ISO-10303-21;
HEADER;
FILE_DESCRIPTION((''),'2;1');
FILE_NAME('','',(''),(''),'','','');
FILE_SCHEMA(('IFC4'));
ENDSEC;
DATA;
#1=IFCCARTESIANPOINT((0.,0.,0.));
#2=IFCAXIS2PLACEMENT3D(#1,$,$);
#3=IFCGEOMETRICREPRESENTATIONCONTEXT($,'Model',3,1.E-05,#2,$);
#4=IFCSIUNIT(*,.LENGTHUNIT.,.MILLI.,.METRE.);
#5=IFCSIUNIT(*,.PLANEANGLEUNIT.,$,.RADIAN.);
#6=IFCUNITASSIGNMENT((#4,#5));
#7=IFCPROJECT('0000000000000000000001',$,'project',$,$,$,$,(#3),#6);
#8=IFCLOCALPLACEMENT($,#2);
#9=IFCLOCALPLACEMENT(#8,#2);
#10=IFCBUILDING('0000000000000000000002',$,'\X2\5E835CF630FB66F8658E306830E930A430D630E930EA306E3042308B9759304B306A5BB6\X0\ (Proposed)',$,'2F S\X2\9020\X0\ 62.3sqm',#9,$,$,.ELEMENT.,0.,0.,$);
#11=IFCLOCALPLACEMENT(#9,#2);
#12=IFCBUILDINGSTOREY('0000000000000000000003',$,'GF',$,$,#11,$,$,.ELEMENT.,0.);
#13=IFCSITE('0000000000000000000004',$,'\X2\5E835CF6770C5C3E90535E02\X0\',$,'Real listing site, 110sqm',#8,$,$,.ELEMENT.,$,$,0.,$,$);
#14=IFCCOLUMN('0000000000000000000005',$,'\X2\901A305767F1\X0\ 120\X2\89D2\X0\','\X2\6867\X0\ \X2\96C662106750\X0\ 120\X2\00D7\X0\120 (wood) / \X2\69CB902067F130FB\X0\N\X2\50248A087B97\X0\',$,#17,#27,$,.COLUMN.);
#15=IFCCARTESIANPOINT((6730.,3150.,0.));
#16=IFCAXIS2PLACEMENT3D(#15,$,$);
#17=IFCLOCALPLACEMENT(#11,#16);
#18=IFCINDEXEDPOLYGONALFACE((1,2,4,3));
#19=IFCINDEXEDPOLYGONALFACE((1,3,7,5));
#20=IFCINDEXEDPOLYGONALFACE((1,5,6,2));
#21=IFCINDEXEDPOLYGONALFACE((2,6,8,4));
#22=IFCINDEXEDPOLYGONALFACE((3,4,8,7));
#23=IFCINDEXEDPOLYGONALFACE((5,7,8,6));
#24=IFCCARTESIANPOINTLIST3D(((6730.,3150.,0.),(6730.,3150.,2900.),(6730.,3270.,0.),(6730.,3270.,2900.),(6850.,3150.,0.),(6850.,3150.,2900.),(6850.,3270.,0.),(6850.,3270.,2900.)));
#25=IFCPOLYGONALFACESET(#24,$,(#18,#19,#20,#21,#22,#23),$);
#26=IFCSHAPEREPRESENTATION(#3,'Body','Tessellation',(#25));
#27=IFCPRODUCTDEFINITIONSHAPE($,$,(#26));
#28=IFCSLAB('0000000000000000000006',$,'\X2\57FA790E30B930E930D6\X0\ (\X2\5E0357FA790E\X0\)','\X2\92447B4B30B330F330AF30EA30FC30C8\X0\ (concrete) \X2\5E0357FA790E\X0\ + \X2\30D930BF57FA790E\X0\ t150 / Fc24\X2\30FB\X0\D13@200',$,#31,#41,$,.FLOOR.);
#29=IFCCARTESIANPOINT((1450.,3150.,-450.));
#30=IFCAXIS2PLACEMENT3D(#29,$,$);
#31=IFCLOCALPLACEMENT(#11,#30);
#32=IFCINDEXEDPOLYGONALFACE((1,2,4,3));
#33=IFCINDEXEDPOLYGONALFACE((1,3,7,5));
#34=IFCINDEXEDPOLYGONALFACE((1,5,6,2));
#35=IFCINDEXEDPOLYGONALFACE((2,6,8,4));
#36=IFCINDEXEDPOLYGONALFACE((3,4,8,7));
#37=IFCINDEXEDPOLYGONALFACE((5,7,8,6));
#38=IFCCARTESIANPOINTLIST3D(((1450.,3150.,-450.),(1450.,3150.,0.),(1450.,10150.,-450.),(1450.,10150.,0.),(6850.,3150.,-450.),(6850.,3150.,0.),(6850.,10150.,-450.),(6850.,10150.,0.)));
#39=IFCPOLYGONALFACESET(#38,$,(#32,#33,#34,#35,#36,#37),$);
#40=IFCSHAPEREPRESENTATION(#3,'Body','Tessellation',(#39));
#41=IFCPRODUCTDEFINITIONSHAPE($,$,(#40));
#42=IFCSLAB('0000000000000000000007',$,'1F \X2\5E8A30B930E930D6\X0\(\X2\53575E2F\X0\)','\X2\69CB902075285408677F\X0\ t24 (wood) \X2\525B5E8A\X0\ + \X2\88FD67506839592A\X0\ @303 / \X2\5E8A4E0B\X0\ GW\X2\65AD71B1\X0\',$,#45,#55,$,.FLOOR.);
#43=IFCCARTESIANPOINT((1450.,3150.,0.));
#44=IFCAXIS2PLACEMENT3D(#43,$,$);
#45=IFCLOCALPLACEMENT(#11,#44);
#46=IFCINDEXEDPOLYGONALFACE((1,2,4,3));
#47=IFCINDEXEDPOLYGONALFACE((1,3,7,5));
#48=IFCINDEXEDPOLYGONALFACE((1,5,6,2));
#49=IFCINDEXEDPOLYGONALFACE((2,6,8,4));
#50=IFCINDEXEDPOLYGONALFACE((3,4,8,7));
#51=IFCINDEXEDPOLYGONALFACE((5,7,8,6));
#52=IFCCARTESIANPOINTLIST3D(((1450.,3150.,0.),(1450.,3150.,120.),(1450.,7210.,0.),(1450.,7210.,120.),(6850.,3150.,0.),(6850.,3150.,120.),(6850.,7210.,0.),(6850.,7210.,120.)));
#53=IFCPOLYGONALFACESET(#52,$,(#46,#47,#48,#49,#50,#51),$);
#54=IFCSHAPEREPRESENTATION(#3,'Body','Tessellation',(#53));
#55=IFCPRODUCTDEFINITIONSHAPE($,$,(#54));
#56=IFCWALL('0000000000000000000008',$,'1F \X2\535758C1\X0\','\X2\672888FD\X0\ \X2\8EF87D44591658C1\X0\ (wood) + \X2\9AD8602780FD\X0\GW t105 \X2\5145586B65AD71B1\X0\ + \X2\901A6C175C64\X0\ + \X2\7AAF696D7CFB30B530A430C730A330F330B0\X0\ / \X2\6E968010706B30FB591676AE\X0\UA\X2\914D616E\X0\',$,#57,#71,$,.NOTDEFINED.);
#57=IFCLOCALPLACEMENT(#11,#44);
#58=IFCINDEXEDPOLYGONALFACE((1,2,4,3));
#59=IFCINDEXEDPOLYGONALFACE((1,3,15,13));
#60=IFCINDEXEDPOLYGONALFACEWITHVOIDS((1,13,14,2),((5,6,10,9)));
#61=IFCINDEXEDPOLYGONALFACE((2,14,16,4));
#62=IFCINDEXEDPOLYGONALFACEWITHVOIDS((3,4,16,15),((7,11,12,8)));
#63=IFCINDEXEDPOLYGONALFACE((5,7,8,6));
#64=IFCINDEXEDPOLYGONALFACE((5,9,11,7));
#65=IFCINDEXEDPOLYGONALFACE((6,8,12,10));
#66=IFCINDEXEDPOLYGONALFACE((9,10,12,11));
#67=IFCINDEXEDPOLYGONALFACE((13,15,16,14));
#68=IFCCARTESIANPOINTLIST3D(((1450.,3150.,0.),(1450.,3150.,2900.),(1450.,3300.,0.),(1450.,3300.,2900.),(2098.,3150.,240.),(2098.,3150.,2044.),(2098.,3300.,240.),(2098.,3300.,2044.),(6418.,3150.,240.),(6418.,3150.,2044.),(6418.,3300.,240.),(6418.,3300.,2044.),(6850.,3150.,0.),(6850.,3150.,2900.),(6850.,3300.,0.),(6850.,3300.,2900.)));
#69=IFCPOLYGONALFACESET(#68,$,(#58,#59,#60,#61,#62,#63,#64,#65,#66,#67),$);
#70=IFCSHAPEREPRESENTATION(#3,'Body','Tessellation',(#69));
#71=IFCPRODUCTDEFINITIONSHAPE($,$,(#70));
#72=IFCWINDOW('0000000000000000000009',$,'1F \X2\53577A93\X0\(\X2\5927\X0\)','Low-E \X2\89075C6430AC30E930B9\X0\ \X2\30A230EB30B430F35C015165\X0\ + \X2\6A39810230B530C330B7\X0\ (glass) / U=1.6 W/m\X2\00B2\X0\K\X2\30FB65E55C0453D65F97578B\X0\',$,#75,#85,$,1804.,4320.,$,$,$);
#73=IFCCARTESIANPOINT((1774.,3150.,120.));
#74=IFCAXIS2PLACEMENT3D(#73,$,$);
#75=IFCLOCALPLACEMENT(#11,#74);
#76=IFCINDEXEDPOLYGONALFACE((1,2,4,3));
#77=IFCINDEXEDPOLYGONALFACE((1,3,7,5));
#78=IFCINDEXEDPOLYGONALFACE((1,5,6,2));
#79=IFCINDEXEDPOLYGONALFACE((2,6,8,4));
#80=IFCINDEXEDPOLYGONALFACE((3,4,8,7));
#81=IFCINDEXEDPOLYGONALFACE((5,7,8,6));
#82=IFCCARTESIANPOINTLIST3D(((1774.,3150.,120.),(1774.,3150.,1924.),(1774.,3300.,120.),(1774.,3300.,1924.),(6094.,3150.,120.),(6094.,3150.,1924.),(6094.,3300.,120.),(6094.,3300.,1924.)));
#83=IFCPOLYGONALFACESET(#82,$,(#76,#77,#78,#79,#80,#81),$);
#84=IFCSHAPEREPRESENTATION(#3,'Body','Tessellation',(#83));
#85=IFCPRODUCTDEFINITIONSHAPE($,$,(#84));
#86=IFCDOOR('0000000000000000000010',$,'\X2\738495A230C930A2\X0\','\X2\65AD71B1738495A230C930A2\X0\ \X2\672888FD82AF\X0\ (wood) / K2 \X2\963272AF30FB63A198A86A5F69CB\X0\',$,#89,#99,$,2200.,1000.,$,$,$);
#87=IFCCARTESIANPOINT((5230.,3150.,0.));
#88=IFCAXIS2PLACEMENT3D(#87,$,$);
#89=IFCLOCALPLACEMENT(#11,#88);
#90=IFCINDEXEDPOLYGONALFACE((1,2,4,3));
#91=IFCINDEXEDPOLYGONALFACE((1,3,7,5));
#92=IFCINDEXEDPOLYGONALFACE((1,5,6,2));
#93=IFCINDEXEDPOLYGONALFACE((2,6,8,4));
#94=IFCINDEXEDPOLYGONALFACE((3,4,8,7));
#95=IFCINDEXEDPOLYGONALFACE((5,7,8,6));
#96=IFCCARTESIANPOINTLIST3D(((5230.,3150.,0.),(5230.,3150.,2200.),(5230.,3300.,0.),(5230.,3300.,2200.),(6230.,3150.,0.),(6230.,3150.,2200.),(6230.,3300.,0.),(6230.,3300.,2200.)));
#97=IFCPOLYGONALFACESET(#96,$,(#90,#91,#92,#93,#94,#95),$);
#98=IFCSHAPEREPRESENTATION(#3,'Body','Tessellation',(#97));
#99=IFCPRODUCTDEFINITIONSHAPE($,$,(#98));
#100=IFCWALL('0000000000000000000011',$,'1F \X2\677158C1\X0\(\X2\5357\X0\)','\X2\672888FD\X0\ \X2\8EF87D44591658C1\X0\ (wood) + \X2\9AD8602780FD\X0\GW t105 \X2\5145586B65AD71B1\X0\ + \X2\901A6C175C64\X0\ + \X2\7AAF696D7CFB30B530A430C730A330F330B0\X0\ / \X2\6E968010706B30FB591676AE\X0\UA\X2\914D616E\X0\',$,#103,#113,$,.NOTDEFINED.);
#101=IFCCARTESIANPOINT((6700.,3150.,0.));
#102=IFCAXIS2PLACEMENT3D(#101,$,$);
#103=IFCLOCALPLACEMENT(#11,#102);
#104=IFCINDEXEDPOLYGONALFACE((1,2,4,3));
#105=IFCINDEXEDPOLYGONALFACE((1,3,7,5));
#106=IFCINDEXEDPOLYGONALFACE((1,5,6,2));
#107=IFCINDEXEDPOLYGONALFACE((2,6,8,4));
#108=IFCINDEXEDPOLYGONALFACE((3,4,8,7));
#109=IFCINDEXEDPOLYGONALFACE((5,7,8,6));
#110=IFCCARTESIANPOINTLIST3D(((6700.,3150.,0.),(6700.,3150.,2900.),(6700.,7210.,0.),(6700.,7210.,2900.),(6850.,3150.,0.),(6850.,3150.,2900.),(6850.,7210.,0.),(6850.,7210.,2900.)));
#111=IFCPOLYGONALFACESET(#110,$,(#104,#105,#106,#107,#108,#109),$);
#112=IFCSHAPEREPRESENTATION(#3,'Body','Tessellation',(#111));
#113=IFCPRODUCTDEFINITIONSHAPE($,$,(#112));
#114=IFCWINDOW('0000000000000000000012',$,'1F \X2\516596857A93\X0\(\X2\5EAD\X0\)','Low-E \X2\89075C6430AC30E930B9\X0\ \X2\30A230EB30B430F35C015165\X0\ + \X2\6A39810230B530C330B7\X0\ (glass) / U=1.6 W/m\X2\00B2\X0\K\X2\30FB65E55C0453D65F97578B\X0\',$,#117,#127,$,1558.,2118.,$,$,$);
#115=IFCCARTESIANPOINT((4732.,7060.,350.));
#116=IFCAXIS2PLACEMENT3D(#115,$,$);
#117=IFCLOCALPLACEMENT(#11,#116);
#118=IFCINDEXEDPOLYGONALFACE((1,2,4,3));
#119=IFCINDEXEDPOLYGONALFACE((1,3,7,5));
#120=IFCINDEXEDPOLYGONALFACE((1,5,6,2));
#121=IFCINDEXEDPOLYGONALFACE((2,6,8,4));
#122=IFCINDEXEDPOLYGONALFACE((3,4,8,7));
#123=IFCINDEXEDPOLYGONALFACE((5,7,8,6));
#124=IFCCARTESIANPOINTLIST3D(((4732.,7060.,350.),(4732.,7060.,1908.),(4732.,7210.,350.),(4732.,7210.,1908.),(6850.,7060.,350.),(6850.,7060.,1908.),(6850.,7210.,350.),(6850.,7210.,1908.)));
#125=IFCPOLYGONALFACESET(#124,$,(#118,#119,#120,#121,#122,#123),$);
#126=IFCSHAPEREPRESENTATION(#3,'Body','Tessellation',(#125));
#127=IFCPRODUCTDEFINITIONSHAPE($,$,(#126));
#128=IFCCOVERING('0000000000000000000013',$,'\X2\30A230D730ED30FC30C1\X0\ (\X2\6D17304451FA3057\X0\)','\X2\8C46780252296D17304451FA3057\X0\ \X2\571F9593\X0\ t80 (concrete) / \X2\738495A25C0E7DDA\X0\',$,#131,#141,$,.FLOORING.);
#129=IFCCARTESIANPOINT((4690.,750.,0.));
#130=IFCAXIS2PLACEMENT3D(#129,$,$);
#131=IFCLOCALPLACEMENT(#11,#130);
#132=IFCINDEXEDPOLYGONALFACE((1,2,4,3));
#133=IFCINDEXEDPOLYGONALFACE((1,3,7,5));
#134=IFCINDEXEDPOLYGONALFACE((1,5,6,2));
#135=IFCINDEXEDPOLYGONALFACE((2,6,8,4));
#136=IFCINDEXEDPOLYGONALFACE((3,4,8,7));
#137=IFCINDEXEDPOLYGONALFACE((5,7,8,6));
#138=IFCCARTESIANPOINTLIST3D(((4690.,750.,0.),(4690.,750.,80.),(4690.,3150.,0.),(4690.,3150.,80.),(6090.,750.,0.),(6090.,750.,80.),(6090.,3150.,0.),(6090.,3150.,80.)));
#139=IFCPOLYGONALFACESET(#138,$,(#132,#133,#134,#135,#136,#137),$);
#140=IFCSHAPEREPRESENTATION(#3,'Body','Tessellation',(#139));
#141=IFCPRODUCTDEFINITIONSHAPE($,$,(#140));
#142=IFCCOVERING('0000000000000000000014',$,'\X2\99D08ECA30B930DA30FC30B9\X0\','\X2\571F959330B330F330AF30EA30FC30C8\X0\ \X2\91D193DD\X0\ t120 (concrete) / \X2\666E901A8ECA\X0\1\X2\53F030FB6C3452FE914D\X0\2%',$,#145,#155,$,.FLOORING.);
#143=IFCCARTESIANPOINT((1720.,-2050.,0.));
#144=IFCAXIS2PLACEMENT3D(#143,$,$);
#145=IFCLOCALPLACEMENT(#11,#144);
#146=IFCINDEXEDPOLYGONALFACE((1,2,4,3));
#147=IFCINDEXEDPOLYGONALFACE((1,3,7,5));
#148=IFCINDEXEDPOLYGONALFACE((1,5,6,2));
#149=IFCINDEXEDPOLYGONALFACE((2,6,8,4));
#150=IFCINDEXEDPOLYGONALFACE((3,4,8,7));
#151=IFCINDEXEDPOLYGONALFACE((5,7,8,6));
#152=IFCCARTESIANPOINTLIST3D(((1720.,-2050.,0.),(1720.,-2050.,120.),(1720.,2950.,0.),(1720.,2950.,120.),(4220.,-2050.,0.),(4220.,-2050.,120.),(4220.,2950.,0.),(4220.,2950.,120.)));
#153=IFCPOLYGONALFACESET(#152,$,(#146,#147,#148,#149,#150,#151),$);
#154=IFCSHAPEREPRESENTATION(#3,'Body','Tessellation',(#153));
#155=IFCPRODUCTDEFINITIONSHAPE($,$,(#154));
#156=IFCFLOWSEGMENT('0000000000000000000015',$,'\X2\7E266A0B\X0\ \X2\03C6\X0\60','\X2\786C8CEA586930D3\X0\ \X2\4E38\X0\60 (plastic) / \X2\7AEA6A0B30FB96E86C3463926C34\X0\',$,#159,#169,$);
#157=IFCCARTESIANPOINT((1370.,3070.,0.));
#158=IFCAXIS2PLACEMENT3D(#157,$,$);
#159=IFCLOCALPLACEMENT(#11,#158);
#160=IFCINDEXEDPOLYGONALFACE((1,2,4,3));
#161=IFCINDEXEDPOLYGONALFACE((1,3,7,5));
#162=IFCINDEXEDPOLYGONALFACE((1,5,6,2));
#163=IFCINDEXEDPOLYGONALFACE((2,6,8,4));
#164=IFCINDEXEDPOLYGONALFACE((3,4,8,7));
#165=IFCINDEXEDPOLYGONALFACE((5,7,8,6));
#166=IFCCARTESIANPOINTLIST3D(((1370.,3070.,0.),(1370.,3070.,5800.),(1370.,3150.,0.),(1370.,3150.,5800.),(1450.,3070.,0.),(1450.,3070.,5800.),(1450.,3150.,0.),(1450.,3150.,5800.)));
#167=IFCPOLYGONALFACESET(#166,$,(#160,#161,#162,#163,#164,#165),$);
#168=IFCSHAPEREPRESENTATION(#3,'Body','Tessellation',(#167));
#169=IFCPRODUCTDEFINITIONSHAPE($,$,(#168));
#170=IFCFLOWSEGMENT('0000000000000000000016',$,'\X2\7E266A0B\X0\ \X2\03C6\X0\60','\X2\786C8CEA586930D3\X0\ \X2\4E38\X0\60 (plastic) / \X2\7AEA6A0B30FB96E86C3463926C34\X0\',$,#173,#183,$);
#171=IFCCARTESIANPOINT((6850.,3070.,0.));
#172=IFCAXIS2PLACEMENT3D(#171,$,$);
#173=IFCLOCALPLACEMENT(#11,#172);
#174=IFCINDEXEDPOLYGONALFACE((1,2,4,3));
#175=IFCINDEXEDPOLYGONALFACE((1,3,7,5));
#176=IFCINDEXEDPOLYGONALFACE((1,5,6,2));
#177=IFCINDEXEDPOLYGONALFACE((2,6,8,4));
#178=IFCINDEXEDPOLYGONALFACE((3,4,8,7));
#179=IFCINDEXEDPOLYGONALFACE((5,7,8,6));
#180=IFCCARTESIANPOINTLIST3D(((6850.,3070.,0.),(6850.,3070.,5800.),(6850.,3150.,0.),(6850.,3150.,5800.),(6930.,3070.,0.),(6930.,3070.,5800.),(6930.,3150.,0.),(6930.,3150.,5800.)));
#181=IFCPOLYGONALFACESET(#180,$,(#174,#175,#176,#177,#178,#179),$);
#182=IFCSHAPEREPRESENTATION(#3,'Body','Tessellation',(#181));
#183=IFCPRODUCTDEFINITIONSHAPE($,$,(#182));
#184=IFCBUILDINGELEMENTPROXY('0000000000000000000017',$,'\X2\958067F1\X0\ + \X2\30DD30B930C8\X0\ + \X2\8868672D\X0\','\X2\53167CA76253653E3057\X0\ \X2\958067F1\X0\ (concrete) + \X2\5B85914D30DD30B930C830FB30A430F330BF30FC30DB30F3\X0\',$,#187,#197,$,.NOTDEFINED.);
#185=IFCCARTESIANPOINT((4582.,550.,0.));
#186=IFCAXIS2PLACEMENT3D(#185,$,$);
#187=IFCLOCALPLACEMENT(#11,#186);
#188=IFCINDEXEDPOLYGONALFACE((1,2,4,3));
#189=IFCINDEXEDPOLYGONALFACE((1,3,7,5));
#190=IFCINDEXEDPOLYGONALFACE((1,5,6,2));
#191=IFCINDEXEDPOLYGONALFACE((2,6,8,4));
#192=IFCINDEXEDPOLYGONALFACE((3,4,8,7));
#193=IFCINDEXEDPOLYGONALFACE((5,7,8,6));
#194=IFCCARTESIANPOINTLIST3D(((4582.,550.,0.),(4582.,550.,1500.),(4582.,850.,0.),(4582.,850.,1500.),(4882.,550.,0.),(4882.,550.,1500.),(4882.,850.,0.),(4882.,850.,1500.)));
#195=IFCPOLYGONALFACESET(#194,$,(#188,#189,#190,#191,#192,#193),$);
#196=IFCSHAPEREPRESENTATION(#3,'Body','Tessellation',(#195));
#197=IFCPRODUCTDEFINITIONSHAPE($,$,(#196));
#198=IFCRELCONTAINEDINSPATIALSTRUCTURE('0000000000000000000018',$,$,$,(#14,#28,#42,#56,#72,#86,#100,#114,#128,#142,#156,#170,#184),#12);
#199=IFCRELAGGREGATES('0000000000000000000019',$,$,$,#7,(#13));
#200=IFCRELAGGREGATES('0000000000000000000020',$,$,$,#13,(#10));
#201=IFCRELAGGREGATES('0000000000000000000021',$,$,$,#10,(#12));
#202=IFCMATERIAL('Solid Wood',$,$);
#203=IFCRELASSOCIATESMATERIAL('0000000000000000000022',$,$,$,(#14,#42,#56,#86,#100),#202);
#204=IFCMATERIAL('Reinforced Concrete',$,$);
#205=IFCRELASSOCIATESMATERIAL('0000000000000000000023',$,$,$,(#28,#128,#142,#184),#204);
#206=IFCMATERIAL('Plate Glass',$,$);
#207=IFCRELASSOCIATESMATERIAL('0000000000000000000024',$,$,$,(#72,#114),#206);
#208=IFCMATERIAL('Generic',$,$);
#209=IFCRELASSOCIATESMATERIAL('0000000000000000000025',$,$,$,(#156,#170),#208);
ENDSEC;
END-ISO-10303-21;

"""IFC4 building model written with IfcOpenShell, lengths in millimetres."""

from ifc_helpers import new_model, si_unit, frame, frame_2d, origin, place, context, project, spatial, rectangle, extrude, material, element, fill, save


model = new_model("IFC4")

# Units and contexts
model_context = context("Model", 3, precision=1e-05, world=origin())
ifc_project = project(units=[si_unit("LENGTHUNIT", "METRE", prefix="MILLI"), si_unit("PLANEANGLEUNIT", "RADIAN")], contexts=[model_context])

# Site, building, storey
site_placement = place(None, origin())
site = spatial("IfcSite", under=ifc_project, at=site_placement, Name="広島県尾道市", ObjectType="Real listing site, 110sqm", CompositionType="ELEMENT", RefElevation=0.0)
building_placement = place(site_placement, origin())
building = spatial("IfcBuilding", under=site, at=building_placement, Name="広島・書斎とライブラリのある静かな家 (Proposed)", ObjectType="2F S造 62.3sqm", CompositionType="ELEMENT", ElevationOfRefHeight=0.0, ElevationOfTerrain=0.0)
storey_placement = place(building_placement, origin())
storey = spatial("IfcBuildingStorey", under=building, at=storey_placement, Name="GF", CompositionType="ELEMENT", Elevation=0.0)

# Column
ifc_material_1 = material(Name="Solid Wood")
column_1_placement = place(storey_placement, frame((6730.0, 3150.0, 0.0)))
element("IfcColumn", 1, at=column_1_placement, inside=storey, material=ifc_material_1, Name="通し柱 120角", Description="桧 集成材 120×120 (wood) / 構造柱・N値計算", PredefinedType="COLUMN", context=model_context, shape_type="SweptSolid", body=[
    extrude(rectangle(XDim=120.0, YDim=120.0, at=frame_2d((60.0, 60.0))), frame((6730.0, 3150.0, 0.0)), (0.0, 0.0, 1.0), 2900.0),
])

# Slabs
ifc_material_2 = material(Name="Reinforced Concrete")
slab_1_placement = place(storey_placement, frame((1450.0, 3150.0, -450.0)))
element("IfcSlab", 2, at=slab_1_placement, inside=storey, material=ifc_material_2, Name="基礎スラブ (布基礎)", Description="鉄筋コンクリート (concrete) 布基礎 + ベタ基礎 t150 / Fc24・D13@200", PredefinedType="FLOOR", context=model_context, shape_type="SweptSolid", body=[
    extrude(rectangle(XDim=5400.0, YDim=7000.0, at=frame_2d((2700.0, 3500.0))), frame((1450.0, 3150.0, -450.0)), (0.0, 0.0, 1.0), 450.0),
])
slab_2_placement = place(storey_placement, frame((1450.0, 3150.0, 0.0)))
element("IfcSlab", 3, at=slab_2_placement, inside=storey, material=ifc_material_1, Name="1F 床スラブ(南帯)", Description="構造用合板 t24 (wood) 剛床 + 製材根太 @303 / 床下 GW断熱", PredefinedType="FLOOR", context=model_context, shape_type="SweptSolid", body=[
    extrude(rectangle(XDim=5400.0, YDim=4060.0, at=frame_2d((2700.0, 2030.0))), frame((1450.0, 3150.0, 0.0)), (0.0, 0.0, 1.0), 120.0),
])

# Wall, openings, window, door
wall_1_placement = place(storey_placement, frame((1450.0, 3150.0, 0.0)))
wall_1 = element("IfcWall", 4, at=wall_1_placement, inside=storey, material=ifc_material_1, Name="1F 南壁", Description="木製 軸組外壁 (wood) + 高性能GW t105 充填断熱 + 通気層 + 窯業系サイディング / 準耐火・外皮UA配慮", PredefinedType="NOTDEFINED", context=model_context, shape_type="SweptSolid", body=[
    extrude(rectangle(XDim=5400.0, YDim=150.0, at=frame_2d((2700.0, 75.0))), frame((1450.0, 3150.0, 0.0)), (0.0, 0.0, 1.0), 2900.0),
])
opening_1_placement = place(storey_placement, frame((1774.0, 3150.0, 120.0)))
opening_1 = element("IfcOpeningElement", 5, at=opening_1_placement, cuts=wall_1, PredefinedType="NOTDEFINED", context=model_context, shape_type="SweptSolid", body=[
    extrude(rectangle(XDim=4320.0, YDim=150.0, at=frame_2d((2160.0, 75.0))), frame((1774.0, 3150.0, 120.0)), (0.0, 0.0, 1.0), 1804.0),
])
opening_2_placement = place(storey_placement, frame((5230.0, 3150.0, 0.0)))
opening_2 = element("IfcOpeningElement", 6, at=opening_2_placement, cuts=wall_1, PredefinedType="NOTDEFINED", context=model_context, shape_type="SweptSolid", body=[
    extrude(rectangle(XDim=1000.0, YDim=150.0, at=frame_2d((500.0, 75.0))), frame((5230.0, 3150.0, 0.0)), (0.0, 0.0, 1.0), 2200.0),
])
ifc_material_3 = material(Name="Plate Glass")
window_1_placement = place(storey_placement, frame((1774.0, 3150.0, 120.0)))
window_1 = element("IfcWindow", 7, at=window_1_placement, inside=storey, material=ifc_material_3, Name="1F 南窓(大)", Description="Low-E 複層ガラス アルゴン封入 + 樹脂サッシ (glass) / U=1.6 W/m²K・日射取得型", OverallHeight=1804.0, OverallWidth=4320.0, context=model_context, shape_type="SweptSolid", body=[
    extrude(rectangle(XDim=4320.0, YDim=150.0, at=frame_2d((2160.0, 75.0))), frame((1774.0, 3150.0, 120.0)), (0.0, 0.0, 1.0), 1804.0),
])
fill(opening_1, window_1)
door_1_placement = place(storey_placement, frame((5230.0, 3150.0, 0.0)))
door_1 = element("IfcDoor", 8, at=door_1_placement, inside=storey, material=ifc_material_1, Name="玄関ドア", Description="断熱玄関ドア 木製芯 (wood) / K2 防犯・採風機構", OverallHeight=2200.0, OverallWidth=1000.0, context=model_context, shape_type="SweptSolid", body=[
    extrude(rectangle(XDim=1000.0, YDim=150.0, at=frame_2d((500.0, 75.0))), frame((5230.0, 3150.0, 0.0)), (0.0, 0.0, 1.0), 2200.0),
])
fill(opening_2, door_1)

# Wall, opening, window
wall_2_placement = place(storey_placement, frame((6700.0, 3150.0, 0.0)))
wall_2 = element("IfcWall", 9, at=wall_2_placement, inside=storey, material=ifc_material_1, Name="1F 東壁(南)", Description="木製 軸組外壁 (wood) + 高性能GW t105 充填断熱 + 通気層 + 窯業系サイディング / 準耐火・外皮UA配慮", PredefinedType="NOTDEFINED", context=model_context, shape_type="SweptSolid", body=[
    extrude(rectangle(XDim=150.0, YDim=4060.0, at=frame_2d((75.0, 2030.0))), frame((6700.0, 3150.0, 0.0)), (0.0, 0.0, 1.0), 2900.0),
])
opening_3_placement = place(storey_placement, frame((4732.0, 7060.0, 350.0)))
opening_3 = element("IfcOpeningElement", 10, at=opening_3_placement, cuts=wall_2, PredefinedType="NOTDEFINED", context=model_context, shape_type="SweptSolid", body=[
    extrude(rectangle(XDim=2118.0, YDim=150.0, at=frame_2d((1059.0, 75.0))), frame((4732.0, 7060.0, 350.0)), (0.0, 0.0, 1.0), 1558.0),
])
window_2_placement = place(storey_placement, frame((4732.0, 7060.0, 350.0)))
window_2 = element("IfcWindow", 11, at=window_2_placement, inside=storey, material=ifc_material_3, Name="1F 入隅窓(庭)", Description="Low-E 複層ガラス アルゴン封入 + 樹脂サッシ (glass) / U=1.6 W/m²K・日射取得型", OverallHeight=1558.0, OverallWidth=2118.0, context=model_context, shape_type="SweptSolid", body=[
    extrude(rectangle(XDim=2118.0, YDim=150.0, at=frame_2d((1059.0, 75.0))), frame((4732.0, 7060.0, 350.0)), (0.0, 0.0, 1.0), 1558.0),
])
fill(opening_3, window_2)

# Coverings
covering_1_placement = place(storey_placement, frame((4690.0, 750.0, 0.0)))
element("IfcCovering", 12, at=covering_1_placement, inside=storey, material=ifc_material_2, Name="アプローチ (洗い出し)", Description="豆砂利洗い出し 土間 t80 (concrete) / 玄関導線", PredefinedType="FLOORING", context=model_context, shape_type="SweptSolid", body=[
    extrude(rectangle(XDim=1400.0, YDim=2400.0, at=frame_2d((700.0, 1200.0))), frame((4690.0, 750.0, 0.0)), (0.0, 0.0, 1.0), 80.0),
])
covering_2_placement = place(storey_placement, frame((1720.0, -2050.0, 0.0)))
element("IfcCovering", 13, at=covering_2_placement, inside=storey, material=ifc_material_2, Name="駐車スペース", Description="土間コンクリート 金鏝 t120 (concrete) / 普通車1台・水勾配2%", PredefinedType="FLOORING", context=model_context, shape_type="SweptSolid", body=[
    extrude(rectangle(XDim=2500.0, YDim=5000.0, at=frame_2d((1250.0, 2500.0))), frame((1720.0, -2050.0, 0.0)), (0.0, 0.0, 1.0), 120.0),
])

# Flow segments
ifc_material_4 = material(Name="Generic")
flow_segment_1_placement = place(storey_placement, frame((1370.0, 3070.0, 0.0)))
element("IfcFlowSegment", 14, at=flow_segment_1_placement, inside=storey, material=ifc_material_4, Name="縦樋 φ60", Description="硬質塩ビ 丸60 (plastic) / 竪樋・雨水排水", context=model_context, shape_type="SweptSolid", body=[
    extrude(rectangle(XDim=80.0, YDim=80.0, at=frame_2d((40.0, 40.0))), frame((1370.0, 3070.0, 0.0)), (0.0, 0.0, 1.0), 5800.0),
])
flow_segment_2_placement = place(storey_placement, frame((6850.0, 3070.0, 0.0)))
element("IfcFlowSegment", 15, at=flow_segment_2_placement, inside=storey, material=ifc_material_4, Name="縦樋 φ60", Description="硬質塩ビ 丸60 (plastic) / 竪樋・雨水排水", context=model_context, shape_type="SweptSolid", body=[
    extrude(rectangle(XDim=80.0, YDim=80.0, at=frame_2d((40.0, 40.0))), frame((6850.0, 3070.0, 0.0)), (0.0, 0.0, 1.0), 5800.0),
])

# Building element proxy
proxy_placement = place(storey_placement, frame((4582.0, 550.0, 0.0)))
element("IfcBuildingElementProxy", 16, at=proxy_placement, inside=storey, material=ifc_material_2, Name="門柱 + ポスト + 表札", Description="化粧打放し 門柱 (concrete) + 宅配ポスト・インターホン", PredefinedType="NOTDEFINED", context=model_context, shape_type="SweptSolid", body=[
    extrude(rectangle(XDim=300.0, YDim=300.0, at=frame_2d((150.0, 150.0))), frame((4582.0, 550.0, 0.0)), (0.0, 0.0, 1.0), 1500.0),
])

save(model, "model.ifc")
